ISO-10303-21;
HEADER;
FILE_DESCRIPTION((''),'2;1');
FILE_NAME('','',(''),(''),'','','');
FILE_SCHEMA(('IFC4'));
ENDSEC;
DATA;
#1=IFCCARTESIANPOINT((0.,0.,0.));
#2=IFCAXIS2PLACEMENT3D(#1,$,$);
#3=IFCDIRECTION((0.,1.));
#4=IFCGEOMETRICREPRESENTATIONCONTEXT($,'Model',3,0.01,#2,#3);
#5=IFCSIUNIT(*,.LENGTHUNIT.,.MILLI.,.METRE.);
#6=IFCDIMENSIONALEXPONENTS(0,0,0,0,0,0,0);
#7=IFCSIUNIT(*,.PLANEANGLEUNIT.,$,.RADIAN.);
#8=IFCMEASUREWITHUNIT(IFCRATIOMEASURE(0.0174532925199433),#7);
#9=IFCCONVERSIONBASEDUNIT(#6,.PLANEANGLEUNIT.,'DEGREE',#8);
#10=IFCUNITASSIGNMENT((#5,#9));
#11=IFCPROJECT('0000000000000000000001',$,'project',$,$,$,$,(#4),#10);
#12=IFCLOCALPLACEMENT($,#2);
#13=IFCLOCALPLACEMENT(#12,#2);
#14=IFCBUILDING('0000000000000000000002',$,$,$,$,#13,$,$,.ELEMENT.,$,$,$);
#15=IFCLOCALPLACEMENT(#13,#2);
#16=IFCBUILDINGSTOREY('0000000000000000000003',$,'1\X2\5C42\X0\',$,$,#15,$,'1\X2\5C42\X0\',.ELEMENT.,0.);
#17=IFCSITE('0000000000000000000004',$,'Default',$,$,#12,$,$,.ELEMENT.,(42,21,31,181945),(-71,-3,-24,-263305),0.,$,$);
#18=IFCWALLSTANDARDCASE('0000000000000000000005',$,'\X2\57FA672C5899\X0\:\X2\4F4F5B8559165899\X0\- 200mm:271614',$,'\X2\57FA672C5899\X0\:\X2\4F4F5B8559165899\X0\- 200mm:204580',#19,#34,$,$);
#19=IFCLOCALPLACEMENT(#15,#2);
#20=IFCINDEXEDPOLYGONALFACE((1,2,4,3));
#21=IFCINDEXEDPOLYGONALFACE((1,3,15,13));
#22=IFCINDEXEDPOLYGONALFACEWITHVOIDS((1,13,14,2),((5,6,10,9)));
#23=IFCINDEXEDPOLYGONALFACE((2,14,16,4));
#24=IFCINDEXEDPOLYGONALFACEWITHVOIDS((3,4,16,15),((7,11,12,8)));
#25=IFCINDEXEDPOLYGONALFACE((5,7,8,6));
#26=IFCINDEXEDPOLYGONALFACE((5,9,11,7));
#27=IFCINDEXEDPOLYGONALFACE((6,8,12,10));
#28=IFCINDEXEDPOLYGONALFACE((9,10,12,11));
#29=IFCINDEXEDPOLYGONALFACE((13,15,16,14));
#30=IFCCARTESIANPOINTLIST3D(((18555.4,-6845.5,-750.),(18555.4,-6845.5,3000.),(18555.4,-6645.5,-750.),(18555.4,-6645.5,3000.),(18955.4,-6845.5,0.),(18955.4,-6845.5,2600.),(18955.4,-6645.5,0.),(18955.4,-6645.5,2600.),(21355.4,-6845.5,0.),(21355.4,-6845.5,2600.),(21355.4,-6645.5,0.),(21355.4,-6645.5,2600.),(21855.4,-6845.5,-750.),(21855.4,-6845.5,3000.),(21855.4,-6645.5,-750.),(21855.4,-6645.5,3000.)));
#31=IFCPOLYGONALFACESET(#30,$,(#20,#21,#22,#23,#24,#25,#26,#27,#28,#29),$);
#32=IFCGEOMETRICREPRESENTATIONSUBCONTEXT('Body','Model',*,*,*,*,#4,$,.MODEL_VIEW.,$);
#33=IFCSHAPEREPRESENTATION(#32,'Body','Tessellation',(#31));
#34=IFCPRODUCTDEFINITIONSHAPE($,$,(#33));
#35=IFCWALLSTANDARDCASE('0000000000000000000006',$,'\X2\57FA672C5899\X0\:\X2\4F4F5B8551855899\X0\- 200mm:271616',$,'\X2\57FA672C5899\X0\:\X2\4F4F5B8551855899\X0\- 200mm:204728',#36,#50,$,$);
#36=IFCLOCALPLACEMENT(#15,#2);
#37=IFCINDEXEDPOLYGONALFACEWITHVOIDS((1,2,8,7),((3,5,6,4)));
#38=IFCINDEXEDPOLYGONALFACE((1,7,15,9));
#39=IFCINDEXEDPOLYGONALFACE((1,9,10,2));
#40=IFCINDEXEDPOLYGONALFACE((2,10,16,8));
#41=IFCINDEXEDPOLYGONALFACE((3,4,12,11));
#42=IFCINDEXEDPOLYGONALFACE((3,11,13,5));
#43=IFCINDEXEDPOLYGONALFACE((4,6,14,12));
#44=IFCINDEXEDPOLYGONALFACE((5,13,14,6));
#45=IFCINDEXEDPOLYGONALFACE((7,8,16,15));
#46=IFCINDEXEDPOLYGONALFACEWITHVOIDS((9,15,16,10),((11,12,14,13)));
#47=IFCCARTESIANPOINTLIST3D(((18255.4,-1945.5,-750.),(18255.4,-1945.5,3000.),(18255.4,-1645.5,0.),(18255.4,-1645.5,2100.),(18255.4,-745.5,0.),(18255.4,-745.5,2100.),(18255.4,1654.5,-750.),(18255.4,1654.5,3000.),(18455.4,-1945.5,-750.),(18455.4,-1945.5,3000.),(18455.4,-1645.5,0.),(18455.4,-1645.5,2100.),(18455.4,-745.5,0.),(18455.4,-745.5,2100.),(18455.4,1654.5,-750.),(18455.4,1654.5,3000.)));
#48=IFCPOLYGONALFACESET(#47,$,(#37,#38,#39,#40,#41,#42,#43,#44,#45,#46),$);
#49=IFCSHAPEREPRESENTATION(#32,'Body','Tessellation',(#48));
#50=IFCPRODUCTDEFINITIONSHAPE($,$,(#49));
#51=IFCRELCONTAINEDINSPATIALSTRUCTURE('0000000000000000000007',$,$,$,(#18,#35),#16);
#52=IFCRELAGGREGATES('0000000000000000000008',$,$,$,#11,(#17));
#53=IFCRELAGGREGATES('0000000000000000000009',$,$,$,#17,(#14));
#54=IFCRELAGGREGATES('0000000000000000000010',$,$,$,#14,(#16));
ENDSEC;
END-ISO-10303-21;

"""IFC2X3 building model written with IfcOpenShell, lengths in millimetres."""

from ifc_helpers import new_model, entity, si_unit, converted_unit, direction, frame, frame_2d, origin, place, context, subcontext, project, spatial, polyline, rectangle, extrude, clip, bounded_halfspace, element, save


model = new_model("IFC2X3")

# Units and contexts
model_context = context("Model", 3, precision=0.01, world=origin(), true_north=direction((0.0, 1.0)))
body_context = subcontext(model_context, "Body", "Model", "MODEL_VIEW")
ifc_project = project(units=[si_unit("LENGTHUNIT", "METRE", prefix="MILLI"), converted_unit("PLANEANGLEUNIT", "DEGREE", entity("IfcRatioMeasure", 0.0174532925199433), si_unit("PLANEANGLEUNIT", "RADIAN"), dimensions=[0, 0, 0, 0, 0, 0, 0])], contexts=[model_context])

# Site, building, storey
site_placement = place(None, origin())
site = spatial("IfcSite", under=ifc_project, at=site_placement, Name="Default", CompositionType="ELEMENT", RefLatitude=(42, 21, 31, 181945), RefLongitude=(-71, -3, -24, -263305), RefElevation=0.0)
building_placement = place(site_placement, origin())
building = spatial("IfcBuilding", under=site, at=building_placement, CompositionType="ELEMENT")
storey_placement = place(building_placement, origin())
storey = spatial("IfcBuildingStorey", under=building, at=storey_placement, Name="1层", LongName="1层", CompositionType="ELEMENT", Elevation=0.0)

# Walls, openings
wall_1_placement = place(storey_placement, frame((18555.4, -6745.5, -750.0)))
wall_1 = element("IfcWallStandardCase", 1, at=wall_1_placement, inside=storey, Name="基本墙:住宅外墙- 200mm:271614", ObjectType="基本墙:住宅外墙- 200mm:204580", context=body_context, shape_type="Clipping", body=[
    clip(extrude(rectangle(XDim=3300.0, YDim=200.0, at=frame_2d((1650.0, 0.0), x_axis=(-1.0, 0.0))), origin(), (0.0, 0.0, 1.0), 3750.0), bounded_halfspace(frame((0.0, -100.0, 0.0), z_axis=(-1.0, 0.0, 0.0), x_axis=(0.0, 0.0, -1.0)), False, frame((0.0, -100.0, 0.0), z_axis=(-1.0, 0.0, 0.0), x_axis=(0.0, 0.0, -1.0)), polyline([(0.0, 0.0), (-3750.0, 0.0), (-3750.0, -200.0), (0.0, -200.0), (0.0, 0.0)]))),
])
opening_1_placement = place(wall_1_placement, frame((2800.0, 100.0, 750.0)))
element("IfcOpeningElement", 2, at=opening_1_placement, cuts=wall_1, ObjectType="Opening", context=body_context, shape_type="SweptSolid", body=[
    extrude(rectangle(XDim=2600.0, YDim=2400.0, at=frame_2d((1300.0, 1200.0), x_axis=(1.0, 0.0))), frame((0.0, 0.0, 0.0), z_axis=(0.0, -1.0, 0.0), x_axis=(0.0, 0.0, 1.0)), (0.0, 0.0, 1.0), 200.0),
])
opening_2_placement = place(wall_1_placement, origin())
element("IfcOpeningElement", 3, at=opening_2_placement, cuts=wall_1, ObjectType="Opening", context=body_context, shape_type="SweptSolid", body=[
    extrude(rectangle(XDim=2600.0, YDim=2400.0, at=frame_2d((0.0, 0.0), x_axis=(0.0, 1.0))), frame((1600.0, -1424.0, 5050.0), z_axis=(0.0, 1.0, 0.0), x_axis=(-1.0, 0.0, 0.0)), (0.0, 0.0, 1.0), 3048.0),
])
wall_2_placement = place(storey_placement, frame((18355.4, -1945.5, -750.0), z_axis=(0.0, 0.0, 1.0), x_axis=(0.0, 1.0, 0.0)))
wall_2 = element("IfcWallStandardCase", 4, at=wall_2_placement, inside=storey, Name="基本墙:住宅内墙- 200mm:271616", ObjectType="基本墙:住宅内墙- 200mm:204728", context=body_context, shape_type="SweptSolid", body=[
    extrude(rectangle(XDim=3600.0, YDim=200.0, at=frame_2d((1800.0, 0.0), x_axis=(-1.0, 0.0))), origin(), (0.0, 0.0, 1.0), 3750.0),
])
opening_3_placement = place(wall_2_placement, frame((1200.0, 100.0, 750.0)))
element("IfcOpeningElement", 5, at=opening_3_placement, cuts=wall_2, ObjectType="Opening", context=body_context, shape_type="SweptSolid", body=[
    extrude(rectangle(XDim=2100.0, YDim=900.0, at=frame_2d((1050.0, 450.0), x_axis=(1.0, 0.0))), frame((0.0, 0.0, 0.0), z_axis=(0.0, -1.0, 0.0), x_axis=(0.0, 0.0, 1.0)), (0.0, 0.0, 1.0), 200.0),
])
opening_4_placement = place(wall_2_placement, origin())
element("IfcOpeningElement", 6, at=opening_4_placement, cuts=wall_2, ObjectType="Opening", context=body_context, shape_type="SweptSolid", body=[
    extrude(rectangle(XDim=2100.0, YDim=900.0, at=frame_2d((0.0, 0.0), x_axis=(1.0, 0.0))), frame((750.0, -1424.0, 4800.0), z_axis=(0.0, 1.0, 0.0), x_axis=(0.0, 0.0, 1.0)), (0.0, 0.0, 1.0), 3048.0),
])

save(model, "model.ifc")
